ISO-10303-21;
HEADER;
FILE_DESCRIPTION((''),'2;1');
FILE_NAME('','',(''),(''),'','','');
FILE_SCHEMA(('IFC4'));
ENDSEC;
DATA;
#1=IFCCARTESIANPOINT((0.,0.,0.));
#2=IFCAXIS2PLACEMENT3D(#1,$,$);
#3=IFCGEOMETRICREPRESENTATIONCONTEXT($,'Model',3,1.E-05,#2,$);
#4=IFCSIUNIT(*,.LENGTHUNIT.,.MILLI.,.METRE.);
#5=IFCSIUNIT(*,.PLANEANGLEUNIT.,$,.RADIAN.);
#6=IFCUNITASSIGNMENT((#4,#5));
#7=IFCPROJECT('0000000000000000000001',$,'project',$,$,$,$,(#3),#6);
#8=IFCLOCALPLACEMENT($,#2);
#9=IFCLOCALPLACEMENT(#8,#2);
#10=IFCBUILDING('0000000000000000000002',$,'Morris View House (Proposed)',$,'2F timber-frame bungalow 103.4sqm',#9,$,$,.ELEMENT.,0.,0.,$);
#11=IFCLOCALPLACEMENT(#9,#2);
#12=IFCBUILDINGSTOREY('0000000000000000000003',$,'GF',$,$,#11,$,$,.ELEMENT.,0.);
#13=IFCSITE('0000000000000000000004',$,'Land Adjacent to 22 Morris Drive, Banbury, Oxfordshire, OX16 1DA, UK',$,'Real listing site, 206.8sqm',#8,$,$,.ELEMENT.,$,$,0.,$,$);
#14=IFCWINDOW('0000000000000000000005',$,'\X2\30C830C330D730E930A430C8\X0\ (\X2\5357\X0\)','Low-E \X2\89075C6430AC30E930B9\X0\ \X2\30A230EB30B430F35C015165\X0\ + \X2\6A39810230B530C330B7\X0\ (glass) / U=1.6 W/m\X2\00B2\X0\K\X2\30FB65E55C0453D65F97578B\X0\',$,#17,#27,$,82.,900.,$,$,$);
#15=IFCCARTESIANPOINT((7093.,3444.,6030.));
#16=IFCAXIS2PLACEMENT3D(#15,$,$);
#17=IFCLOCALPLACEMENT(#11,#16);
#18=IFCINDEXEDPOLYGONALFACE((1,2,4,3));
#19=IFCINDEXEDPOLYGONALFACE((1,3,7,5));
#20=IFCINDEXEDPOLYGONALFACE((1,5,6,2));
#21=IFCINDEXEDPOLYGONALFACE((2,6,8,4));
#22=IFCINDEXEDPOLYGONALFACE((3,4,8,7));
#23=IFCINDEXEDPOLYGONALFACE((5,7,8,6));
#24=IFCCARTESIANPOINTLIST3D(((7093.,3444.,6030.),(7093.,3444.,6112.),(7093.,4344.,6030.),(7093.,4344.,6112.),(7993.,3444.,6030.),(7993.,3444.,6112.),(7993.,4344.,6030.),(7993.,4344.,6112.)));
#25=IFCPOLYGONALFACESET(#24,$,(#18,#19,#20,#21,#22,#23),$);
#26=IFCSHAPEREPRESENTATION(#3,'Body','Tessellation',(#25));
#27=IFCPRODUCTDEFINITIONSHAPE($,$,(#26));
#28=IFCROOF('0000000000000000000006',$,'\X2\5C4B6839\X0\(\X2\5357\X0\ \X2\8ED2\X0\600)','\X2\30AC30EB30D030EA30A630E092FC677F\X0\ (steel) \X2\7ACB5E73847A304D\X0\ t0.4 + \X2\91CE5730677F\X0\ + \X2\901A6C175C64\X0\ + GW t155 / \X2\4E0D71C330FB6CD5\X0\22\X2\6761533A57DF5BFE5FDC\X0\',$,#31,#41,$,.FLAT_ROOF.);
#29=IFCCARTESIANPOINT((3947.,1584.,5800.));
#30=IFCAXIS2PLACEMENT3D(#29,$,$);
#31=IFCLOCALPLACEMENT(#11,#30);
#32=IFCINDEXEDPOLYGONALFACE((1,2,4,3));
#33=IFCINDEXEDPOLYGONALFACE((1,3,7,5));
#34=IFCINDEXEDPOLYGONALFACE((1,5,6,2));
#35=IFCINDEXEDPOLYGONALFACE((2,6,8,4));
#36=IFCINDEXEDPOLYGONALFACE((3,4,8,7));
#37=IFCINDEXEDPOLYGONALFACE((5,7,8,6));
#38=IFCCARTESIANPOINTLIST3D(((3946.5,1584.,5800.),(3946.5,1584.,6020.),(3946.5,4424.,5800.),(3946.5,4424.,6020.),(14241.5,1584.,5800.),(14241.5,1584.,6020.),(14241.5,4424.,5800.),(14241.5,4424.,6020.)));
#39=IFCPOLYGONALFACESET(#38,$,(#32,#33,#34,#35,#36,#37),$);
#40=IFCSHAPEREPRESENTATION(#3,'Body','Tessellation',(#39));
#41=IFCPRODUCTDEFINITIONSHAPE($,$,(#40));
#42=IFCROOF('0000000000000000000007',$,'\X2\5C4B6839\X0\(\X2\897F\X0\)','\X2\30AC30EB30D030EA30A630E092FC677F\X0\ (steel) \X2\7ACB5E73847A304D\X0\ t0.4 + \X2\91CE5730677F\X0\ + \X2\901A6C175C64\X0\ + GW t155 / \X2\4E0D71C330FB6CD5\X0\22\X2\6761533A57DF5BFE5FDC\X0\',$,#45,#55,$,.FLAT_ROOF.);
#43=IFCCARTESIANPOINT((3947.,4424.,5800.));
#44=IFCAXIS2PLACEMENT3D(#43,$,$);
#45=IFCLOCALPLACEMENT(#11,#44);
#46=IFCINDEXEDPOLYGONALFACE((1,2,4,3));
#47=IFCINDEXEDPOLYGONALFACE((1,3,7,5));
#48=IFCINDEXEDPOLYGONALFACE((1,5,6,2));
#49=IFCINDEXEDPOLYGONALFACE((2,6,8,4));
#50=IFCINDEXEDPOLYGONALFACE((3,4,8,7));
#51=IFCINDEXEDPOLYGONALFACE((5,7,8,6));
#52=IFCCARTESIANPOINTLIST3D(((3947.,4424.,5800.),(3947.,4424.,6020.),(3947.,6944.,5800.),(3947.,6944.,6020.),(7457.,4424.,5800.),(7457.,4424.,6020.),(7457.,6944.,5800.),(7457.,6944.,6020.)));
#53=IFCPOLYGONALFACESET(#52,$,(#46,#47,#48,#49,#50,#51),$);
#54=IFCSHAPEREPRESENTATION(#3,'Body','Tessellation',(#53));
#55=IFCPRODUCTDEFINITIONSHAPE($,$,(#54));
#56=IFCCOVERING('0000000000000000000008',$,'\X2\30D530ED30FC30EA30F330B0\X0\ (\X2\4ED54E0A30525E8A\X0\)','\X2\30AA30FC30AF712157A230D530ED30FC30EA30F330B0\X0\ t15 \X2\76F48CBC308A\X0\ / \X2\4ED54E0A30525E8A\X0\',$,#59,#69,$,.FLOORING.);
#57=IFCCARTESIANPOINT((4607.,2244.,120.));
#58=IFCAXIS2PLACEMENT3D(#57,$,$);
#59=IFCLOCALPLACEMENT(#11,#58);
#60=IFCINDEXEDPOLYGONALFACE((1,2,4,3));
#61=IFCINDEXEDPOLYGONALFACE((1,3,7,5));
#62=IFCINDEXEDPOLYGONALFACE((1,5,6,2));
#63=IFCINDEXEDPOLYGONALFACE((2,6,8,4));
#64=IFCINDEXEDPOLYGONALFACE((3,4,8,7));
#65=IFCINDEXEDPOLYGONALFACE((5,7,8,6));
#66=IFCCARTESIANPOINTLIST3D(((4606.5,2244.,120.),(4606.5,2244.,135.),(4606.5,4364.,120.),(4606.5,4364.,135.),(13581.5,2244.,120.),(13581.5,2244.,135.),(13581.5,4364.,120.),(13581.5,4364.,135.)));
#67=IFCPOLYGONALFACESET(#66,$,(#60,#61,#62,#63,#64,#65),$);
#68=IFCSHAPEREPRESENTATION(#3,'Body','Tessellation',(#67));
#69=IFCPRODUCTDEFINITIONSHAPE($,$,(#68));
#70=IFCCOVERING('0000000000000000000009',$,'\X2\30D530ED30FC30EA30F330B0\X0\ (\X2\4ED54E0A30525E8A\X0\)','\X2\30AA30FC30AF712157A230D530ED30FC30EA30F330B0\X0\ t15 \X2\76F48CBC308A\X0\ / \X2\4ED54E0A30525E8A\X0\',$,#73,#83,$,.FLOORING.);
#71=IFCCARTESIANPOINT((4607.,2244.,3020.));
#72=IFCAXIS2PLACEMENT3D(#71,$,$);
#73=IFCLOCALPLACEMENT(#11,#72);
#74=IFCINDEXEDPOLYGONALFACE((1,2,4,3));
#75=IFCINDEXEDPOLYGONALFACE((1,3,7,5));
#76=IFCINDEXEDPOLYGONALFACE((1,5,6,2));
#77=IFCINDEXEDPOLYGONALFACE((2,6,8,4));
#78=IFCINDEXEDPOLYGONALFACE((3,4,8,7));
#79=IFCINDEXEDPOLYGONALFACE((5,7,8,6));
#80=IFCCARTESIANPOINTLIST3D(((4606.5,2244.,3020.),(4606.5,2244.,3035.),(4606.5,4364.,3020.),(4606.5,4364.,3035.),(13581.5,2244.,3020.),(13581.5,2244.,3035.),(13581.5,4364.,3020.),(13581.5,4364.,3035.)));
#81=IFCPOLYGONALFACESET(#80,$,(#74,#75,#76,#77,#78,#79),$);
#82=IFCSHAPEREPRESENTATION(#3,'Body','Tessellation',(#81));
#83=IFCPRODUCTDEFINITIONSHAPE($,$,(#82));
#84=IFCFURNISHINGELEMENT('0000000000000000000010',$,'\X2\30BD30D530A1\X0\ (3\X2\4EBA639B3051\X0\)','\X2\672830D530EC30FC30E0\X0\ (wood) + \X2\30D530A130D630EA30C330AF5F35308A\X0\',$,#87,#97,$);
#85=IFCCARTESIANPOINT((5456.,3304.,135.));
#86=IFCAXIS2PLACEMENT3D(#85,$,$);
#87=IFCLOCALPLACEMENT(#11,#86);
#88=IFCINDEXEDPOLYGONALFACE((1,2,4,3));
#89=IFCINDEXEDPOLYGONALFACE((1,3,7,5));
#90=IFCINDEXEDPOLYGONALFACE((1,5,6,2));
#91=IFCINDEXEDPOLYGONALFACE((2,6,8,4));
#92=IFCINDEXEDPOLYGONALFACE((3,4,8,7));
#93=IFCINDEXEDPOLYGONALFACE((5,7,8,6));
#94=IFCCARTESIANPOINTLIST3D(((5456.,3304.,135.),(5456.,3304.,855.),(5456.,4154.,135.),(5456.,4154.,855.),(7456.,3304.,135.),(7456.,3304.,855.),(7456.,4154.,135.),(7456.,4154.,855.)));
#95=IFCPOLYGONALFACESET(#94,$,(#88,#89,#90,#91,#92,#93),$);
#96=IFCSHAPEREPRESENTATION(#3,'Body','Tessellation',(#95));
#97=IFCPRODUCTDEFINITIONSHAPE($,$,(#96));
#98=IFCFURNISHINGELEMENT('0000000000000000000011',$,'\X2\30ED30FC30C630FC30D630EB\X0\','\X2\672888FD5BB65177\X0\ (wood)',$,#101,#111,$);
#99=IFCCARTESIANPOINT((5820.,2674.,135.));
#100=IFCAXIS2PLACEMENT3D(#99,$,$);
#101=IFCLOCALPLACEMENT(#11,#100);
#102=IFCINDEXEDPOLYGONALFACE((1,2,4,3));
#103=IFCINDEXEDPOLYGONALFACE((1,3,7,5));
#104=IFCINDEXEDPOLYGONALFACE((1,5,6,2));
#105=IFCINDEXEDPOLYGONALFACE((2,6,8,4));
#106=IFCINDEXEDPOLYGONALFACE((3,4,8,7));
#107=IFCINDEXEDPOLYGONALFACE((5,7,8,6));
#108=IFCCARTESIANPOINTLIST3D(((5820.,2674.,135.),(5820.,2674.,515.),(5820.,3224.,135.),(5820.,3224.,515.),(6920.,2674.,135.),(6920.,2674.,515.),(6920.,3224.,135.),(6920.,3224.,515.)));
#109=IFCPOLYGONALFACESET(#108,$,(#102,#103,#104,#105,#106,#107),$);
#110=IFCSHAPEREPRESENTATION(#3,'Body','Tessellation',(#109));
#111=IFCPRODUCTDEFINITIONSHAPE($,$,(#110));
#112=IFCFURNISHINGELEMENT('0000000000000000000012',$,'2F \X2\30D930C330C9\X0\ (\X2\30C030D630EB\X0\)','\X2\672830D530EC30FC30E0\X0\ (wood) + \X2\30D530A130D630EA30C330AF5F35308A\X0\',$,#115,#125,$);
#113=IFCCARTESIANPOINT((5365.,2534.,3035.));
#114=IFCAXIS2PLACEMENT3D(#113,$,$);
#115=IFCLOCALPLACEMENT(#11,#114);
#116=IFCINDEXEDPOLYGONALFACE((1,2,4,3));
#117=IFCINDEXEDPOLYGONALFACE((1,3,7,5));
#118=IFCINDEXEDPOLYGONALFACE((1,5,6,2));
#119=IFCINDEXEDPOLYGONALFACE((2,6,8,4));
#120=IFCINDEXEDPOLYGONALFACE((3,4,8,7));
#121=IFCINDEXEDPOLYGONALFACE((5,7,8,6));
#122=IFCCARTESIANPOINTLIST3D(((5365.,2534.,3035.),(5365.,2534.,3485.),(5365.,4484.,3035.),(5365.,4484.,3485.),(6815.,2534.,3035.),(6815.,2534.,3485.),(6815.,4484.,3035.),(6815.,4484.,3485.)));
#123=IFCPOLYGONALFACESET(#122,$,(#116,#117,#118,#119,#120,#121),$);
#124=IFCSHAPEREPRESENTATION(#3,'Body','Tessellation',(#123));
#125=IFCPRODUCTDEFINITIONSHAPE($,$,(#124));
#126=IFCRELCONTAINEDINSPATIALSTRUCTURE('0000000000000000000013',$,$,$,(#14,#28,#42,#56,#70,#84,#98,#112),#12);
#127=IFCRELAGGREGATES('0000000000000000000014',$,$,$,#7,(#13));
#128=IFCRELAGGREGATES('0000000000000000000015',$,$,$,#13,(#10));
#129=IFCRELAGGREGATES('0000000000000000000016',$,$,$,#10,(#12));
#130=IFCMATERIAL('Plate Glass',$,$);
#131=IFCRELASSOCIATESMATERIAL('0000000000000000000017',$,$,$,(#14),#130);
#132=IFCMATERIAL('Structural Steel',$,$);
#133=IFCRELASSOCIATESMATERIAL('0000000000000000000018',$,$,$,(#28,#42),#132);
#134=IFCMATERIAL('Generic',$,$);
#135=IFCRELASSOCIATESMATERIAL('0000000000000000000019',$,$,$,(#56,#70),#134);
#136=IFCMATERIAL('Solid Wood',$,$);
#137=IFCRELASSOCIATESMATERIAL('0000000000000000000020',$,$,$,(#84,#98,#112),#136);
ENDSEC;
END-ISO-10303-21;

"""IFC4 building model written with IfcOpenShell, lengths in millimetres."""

from ifc_helpers import new_model, si_unit, frame, frame_2d, origin, place, context, project, spatial, rectangle, extrude, material, element, save


model = new_model("IFC4")

# Units and contexts
model_context = context("Model", 3, precision=1e-05, world=origin())
ifc_project = project(units=[si_unit("LENGTHUNIT", "METRE", prefix="MILLI"), si_unit("PLANEANGLEUNIT", "RADIAN")], contexts=[model_context])

# Site, building, storey
site_placement = place(None, origin())
site = spatial("IfcSite", under=ifc_project, at=site_placement, Name="Land Adjacent to 22 Morris Drive, Banbury, Oxfordshire, OX16 1DA, UK", ObjectType="Real listing site, 206.8sqm", CompositionType="ELEMENT", RefElevation=0.0)
building_placement = place(site_placement, origin())
building = spatial("IfcBuilding", under=site, at=building_placement, Name="Morris View House (Proposed)", ObjectType="2F timber-frame bungalow 103.4sqm", CompositionType="ELEMENT", ElevationOfRefHeight=0.0, ElevationOfTerrain=0.0)
storey_placement = place(building_placement, origin())
storey = spatial("IfcBuildingStorey", under=building, at=storey_placement, Name="GF", CompositionType="ELEMENT", Elevation=0.0)

# Shared definitions
ifc_material_1 = material(Name="Solid Wood")

# Shared definitions
ifc_material_2 = material(Name="Plate Glass")

# Window
window_1_placement = place(storey_placement, frame((7093.0, 3444.0, 6030.0)))
element("IfcWindow", 1, at=window_1_placement, inside=storey, material=ifc_material_2, Name="トップライト (南)", Description="Low-E 複層ガラス アルゴン封入 + 樹脂サッシ (glass) / U=1.6 W/m²K・日射取得型", OverallHeight=82.0, OverallWidth=900.0, context=model_context, shape_type="SweptSolid", body=[
    extrude(rectangle(XDim=900.0, YDim=900.0, at=frame_2d((450.0, 450.0))), frame((7093.0, 3444.0, 6030.0)), (0.0, 0.0, 1.0), 82.0),
])

# Roofs
ifc_material_3 = material(Name="Structural Steel")
roof_1_placement = place(storey_placement, frame((3947.0, 1584.0, 5800.0)))
element("IfcRoof", 2, at=roof_1_placement, inside=storey, material=ifc_material_3, Name="屋根(南 軒600)", Description="ガルバリウム鋼板 (steel) 立平葺き t0.4 + 野地板 + 通気層 + GW t155 / 不燃・法22条区域対応", PredefinedType="FLAT_ROOF", context=model_context, shape_type="SweptSolid", body=[
    extrude(rectangle(XDim=10295.0, YDim=2840.0, at=frame_2d((5147.0, 1420.0))), frame((3947.0, 1584.0, 5800.0)), (0.0, 0.0, 1.0), 220.0),
])
roof_2_placement = place(storey_placement, frame((3947.0, 4424.0, 5800.0)))
element("IfcRoof", 3, at=roof_2_placement, inside=storey, material=ifc_material_3, Name="屋根(西)", Description="ガルバリウム鋼板 (steel) 立平葺き t0.4 + 野地板 + 通気層 + GW t155 / 不燃・法22条区域対応", PredefinedType="FLAT_ROOF", context=model_context, shape_type="SweptSolid", body=[
    extrude(rectangle(XDim=3510.0, YDim=2520.0, at=frame_2d((1755.0, 1260.0))), frame((3947.0, 4424.0, 5800.0)), (0.0, 0.0, 1.0), 220.0),
])

# Coverings
ifc_material_4 = material(Name="Generic")
covering_1_placement = place(storey_placement, frame((4607.0, 2244.0, 120.0)))
element("IfcCovering", 4, at=covering_1_placement, inside=storey, material=ifc_material_4, Name="フローリング (仕上げ床)", Description="オーク無垢フローリング t15 直貼り / 仕上げ床", PredefinedType="FLOORING", context=model_context, shape_type="SweptSolid", body=[
    extrude(rectangle(XDim=8975.0, YDim=2120.0, at=frame_2d((4487.0, 1060.0))), frame((4607.0, 2244.0, 120.0)), (0.0, 0.0, 1.0), 15.0),
])
covering_2_placement = place(storey_placement, frame((4607.0, 2244.0, 3020.0)))
element("IfcCovering", 5, at=covering_2_placement, inside=storey, material=ifc_material_4, Name="フローリング (仕上げ床)", Description="オーク無垢フローリング t15 直貼り / 仕上げ床", PredefinedType="FLOORING", context=model_context, shape_type="SweptSolid", body=[
    extrude(rectangle(XDim=8975.0, YDim=2120.0, at=frame_2d((4487.0, 1060.0))), frame((4607.0, 2244.0, 3020.0)), (0.0, 0.0, 1.0), 15.0),
])

# Furnishing elements
furnishing_1_placement = place(storey_placement, frame((5456.0, 3304.0, 135.0)))
element("IfcFurnishingElement", 6, at=furnishing_1_placement, inside=storey, material=ifc_material_1, Name="ソファ (3人掛け)", Description="木フレーム (wood) + ファブリック張り", context=model_context, shape_type="SweptSolid", body=[
    extrude(rectangle(XDim=2000.0, YDim=850.0, at=frame_2d((1000.0, 425.0))), frame((5456.0, 3304.0, 135.0)), (0.0, 0.0, 1.0), 720.0),
])
furnishing_2_placement = place(storey_placement, frame((5820.0, 2674.0, 135.0)))
element("IfcFurnishingElement", 7, at=furnishing_2_placement, inside=storey, material=ifc_material_1, Name="ローテーブル", Description="木製家具 (wood)", context=model_context, shape_type="SweptSolid", body=[
    extrude(rectangle(XDim=1100.0, YDim=550.0, at=frame_2d((550.0, 275.0))), frame((5820.0, 2674.0, 135.0)), (0.0, 0.0, 1.0), 380.0),
])
furnishing_3_placement = place(storey_placement, frame((5365.0, 2534.0, 3035.0)))
element("IfcFurnishingElement", 8, at=furnishing_3_placement, inside=storey, material=ifc_material_1, Name="2F ベッド (ダブル)", Description="木フレーム (wood) + ファブリック張り", context=model_context, shape_type="SweptSolid", body=[
    extrude(rectangle(XDim=1450.0, YDim=1950.0, at=frame_2d((725.0, 975.0))), frame((5365.0, 2534.0, 3035.0)), (0.0, 0.0, 1.0), 450.0),
])

save(model, "model.ifc")
